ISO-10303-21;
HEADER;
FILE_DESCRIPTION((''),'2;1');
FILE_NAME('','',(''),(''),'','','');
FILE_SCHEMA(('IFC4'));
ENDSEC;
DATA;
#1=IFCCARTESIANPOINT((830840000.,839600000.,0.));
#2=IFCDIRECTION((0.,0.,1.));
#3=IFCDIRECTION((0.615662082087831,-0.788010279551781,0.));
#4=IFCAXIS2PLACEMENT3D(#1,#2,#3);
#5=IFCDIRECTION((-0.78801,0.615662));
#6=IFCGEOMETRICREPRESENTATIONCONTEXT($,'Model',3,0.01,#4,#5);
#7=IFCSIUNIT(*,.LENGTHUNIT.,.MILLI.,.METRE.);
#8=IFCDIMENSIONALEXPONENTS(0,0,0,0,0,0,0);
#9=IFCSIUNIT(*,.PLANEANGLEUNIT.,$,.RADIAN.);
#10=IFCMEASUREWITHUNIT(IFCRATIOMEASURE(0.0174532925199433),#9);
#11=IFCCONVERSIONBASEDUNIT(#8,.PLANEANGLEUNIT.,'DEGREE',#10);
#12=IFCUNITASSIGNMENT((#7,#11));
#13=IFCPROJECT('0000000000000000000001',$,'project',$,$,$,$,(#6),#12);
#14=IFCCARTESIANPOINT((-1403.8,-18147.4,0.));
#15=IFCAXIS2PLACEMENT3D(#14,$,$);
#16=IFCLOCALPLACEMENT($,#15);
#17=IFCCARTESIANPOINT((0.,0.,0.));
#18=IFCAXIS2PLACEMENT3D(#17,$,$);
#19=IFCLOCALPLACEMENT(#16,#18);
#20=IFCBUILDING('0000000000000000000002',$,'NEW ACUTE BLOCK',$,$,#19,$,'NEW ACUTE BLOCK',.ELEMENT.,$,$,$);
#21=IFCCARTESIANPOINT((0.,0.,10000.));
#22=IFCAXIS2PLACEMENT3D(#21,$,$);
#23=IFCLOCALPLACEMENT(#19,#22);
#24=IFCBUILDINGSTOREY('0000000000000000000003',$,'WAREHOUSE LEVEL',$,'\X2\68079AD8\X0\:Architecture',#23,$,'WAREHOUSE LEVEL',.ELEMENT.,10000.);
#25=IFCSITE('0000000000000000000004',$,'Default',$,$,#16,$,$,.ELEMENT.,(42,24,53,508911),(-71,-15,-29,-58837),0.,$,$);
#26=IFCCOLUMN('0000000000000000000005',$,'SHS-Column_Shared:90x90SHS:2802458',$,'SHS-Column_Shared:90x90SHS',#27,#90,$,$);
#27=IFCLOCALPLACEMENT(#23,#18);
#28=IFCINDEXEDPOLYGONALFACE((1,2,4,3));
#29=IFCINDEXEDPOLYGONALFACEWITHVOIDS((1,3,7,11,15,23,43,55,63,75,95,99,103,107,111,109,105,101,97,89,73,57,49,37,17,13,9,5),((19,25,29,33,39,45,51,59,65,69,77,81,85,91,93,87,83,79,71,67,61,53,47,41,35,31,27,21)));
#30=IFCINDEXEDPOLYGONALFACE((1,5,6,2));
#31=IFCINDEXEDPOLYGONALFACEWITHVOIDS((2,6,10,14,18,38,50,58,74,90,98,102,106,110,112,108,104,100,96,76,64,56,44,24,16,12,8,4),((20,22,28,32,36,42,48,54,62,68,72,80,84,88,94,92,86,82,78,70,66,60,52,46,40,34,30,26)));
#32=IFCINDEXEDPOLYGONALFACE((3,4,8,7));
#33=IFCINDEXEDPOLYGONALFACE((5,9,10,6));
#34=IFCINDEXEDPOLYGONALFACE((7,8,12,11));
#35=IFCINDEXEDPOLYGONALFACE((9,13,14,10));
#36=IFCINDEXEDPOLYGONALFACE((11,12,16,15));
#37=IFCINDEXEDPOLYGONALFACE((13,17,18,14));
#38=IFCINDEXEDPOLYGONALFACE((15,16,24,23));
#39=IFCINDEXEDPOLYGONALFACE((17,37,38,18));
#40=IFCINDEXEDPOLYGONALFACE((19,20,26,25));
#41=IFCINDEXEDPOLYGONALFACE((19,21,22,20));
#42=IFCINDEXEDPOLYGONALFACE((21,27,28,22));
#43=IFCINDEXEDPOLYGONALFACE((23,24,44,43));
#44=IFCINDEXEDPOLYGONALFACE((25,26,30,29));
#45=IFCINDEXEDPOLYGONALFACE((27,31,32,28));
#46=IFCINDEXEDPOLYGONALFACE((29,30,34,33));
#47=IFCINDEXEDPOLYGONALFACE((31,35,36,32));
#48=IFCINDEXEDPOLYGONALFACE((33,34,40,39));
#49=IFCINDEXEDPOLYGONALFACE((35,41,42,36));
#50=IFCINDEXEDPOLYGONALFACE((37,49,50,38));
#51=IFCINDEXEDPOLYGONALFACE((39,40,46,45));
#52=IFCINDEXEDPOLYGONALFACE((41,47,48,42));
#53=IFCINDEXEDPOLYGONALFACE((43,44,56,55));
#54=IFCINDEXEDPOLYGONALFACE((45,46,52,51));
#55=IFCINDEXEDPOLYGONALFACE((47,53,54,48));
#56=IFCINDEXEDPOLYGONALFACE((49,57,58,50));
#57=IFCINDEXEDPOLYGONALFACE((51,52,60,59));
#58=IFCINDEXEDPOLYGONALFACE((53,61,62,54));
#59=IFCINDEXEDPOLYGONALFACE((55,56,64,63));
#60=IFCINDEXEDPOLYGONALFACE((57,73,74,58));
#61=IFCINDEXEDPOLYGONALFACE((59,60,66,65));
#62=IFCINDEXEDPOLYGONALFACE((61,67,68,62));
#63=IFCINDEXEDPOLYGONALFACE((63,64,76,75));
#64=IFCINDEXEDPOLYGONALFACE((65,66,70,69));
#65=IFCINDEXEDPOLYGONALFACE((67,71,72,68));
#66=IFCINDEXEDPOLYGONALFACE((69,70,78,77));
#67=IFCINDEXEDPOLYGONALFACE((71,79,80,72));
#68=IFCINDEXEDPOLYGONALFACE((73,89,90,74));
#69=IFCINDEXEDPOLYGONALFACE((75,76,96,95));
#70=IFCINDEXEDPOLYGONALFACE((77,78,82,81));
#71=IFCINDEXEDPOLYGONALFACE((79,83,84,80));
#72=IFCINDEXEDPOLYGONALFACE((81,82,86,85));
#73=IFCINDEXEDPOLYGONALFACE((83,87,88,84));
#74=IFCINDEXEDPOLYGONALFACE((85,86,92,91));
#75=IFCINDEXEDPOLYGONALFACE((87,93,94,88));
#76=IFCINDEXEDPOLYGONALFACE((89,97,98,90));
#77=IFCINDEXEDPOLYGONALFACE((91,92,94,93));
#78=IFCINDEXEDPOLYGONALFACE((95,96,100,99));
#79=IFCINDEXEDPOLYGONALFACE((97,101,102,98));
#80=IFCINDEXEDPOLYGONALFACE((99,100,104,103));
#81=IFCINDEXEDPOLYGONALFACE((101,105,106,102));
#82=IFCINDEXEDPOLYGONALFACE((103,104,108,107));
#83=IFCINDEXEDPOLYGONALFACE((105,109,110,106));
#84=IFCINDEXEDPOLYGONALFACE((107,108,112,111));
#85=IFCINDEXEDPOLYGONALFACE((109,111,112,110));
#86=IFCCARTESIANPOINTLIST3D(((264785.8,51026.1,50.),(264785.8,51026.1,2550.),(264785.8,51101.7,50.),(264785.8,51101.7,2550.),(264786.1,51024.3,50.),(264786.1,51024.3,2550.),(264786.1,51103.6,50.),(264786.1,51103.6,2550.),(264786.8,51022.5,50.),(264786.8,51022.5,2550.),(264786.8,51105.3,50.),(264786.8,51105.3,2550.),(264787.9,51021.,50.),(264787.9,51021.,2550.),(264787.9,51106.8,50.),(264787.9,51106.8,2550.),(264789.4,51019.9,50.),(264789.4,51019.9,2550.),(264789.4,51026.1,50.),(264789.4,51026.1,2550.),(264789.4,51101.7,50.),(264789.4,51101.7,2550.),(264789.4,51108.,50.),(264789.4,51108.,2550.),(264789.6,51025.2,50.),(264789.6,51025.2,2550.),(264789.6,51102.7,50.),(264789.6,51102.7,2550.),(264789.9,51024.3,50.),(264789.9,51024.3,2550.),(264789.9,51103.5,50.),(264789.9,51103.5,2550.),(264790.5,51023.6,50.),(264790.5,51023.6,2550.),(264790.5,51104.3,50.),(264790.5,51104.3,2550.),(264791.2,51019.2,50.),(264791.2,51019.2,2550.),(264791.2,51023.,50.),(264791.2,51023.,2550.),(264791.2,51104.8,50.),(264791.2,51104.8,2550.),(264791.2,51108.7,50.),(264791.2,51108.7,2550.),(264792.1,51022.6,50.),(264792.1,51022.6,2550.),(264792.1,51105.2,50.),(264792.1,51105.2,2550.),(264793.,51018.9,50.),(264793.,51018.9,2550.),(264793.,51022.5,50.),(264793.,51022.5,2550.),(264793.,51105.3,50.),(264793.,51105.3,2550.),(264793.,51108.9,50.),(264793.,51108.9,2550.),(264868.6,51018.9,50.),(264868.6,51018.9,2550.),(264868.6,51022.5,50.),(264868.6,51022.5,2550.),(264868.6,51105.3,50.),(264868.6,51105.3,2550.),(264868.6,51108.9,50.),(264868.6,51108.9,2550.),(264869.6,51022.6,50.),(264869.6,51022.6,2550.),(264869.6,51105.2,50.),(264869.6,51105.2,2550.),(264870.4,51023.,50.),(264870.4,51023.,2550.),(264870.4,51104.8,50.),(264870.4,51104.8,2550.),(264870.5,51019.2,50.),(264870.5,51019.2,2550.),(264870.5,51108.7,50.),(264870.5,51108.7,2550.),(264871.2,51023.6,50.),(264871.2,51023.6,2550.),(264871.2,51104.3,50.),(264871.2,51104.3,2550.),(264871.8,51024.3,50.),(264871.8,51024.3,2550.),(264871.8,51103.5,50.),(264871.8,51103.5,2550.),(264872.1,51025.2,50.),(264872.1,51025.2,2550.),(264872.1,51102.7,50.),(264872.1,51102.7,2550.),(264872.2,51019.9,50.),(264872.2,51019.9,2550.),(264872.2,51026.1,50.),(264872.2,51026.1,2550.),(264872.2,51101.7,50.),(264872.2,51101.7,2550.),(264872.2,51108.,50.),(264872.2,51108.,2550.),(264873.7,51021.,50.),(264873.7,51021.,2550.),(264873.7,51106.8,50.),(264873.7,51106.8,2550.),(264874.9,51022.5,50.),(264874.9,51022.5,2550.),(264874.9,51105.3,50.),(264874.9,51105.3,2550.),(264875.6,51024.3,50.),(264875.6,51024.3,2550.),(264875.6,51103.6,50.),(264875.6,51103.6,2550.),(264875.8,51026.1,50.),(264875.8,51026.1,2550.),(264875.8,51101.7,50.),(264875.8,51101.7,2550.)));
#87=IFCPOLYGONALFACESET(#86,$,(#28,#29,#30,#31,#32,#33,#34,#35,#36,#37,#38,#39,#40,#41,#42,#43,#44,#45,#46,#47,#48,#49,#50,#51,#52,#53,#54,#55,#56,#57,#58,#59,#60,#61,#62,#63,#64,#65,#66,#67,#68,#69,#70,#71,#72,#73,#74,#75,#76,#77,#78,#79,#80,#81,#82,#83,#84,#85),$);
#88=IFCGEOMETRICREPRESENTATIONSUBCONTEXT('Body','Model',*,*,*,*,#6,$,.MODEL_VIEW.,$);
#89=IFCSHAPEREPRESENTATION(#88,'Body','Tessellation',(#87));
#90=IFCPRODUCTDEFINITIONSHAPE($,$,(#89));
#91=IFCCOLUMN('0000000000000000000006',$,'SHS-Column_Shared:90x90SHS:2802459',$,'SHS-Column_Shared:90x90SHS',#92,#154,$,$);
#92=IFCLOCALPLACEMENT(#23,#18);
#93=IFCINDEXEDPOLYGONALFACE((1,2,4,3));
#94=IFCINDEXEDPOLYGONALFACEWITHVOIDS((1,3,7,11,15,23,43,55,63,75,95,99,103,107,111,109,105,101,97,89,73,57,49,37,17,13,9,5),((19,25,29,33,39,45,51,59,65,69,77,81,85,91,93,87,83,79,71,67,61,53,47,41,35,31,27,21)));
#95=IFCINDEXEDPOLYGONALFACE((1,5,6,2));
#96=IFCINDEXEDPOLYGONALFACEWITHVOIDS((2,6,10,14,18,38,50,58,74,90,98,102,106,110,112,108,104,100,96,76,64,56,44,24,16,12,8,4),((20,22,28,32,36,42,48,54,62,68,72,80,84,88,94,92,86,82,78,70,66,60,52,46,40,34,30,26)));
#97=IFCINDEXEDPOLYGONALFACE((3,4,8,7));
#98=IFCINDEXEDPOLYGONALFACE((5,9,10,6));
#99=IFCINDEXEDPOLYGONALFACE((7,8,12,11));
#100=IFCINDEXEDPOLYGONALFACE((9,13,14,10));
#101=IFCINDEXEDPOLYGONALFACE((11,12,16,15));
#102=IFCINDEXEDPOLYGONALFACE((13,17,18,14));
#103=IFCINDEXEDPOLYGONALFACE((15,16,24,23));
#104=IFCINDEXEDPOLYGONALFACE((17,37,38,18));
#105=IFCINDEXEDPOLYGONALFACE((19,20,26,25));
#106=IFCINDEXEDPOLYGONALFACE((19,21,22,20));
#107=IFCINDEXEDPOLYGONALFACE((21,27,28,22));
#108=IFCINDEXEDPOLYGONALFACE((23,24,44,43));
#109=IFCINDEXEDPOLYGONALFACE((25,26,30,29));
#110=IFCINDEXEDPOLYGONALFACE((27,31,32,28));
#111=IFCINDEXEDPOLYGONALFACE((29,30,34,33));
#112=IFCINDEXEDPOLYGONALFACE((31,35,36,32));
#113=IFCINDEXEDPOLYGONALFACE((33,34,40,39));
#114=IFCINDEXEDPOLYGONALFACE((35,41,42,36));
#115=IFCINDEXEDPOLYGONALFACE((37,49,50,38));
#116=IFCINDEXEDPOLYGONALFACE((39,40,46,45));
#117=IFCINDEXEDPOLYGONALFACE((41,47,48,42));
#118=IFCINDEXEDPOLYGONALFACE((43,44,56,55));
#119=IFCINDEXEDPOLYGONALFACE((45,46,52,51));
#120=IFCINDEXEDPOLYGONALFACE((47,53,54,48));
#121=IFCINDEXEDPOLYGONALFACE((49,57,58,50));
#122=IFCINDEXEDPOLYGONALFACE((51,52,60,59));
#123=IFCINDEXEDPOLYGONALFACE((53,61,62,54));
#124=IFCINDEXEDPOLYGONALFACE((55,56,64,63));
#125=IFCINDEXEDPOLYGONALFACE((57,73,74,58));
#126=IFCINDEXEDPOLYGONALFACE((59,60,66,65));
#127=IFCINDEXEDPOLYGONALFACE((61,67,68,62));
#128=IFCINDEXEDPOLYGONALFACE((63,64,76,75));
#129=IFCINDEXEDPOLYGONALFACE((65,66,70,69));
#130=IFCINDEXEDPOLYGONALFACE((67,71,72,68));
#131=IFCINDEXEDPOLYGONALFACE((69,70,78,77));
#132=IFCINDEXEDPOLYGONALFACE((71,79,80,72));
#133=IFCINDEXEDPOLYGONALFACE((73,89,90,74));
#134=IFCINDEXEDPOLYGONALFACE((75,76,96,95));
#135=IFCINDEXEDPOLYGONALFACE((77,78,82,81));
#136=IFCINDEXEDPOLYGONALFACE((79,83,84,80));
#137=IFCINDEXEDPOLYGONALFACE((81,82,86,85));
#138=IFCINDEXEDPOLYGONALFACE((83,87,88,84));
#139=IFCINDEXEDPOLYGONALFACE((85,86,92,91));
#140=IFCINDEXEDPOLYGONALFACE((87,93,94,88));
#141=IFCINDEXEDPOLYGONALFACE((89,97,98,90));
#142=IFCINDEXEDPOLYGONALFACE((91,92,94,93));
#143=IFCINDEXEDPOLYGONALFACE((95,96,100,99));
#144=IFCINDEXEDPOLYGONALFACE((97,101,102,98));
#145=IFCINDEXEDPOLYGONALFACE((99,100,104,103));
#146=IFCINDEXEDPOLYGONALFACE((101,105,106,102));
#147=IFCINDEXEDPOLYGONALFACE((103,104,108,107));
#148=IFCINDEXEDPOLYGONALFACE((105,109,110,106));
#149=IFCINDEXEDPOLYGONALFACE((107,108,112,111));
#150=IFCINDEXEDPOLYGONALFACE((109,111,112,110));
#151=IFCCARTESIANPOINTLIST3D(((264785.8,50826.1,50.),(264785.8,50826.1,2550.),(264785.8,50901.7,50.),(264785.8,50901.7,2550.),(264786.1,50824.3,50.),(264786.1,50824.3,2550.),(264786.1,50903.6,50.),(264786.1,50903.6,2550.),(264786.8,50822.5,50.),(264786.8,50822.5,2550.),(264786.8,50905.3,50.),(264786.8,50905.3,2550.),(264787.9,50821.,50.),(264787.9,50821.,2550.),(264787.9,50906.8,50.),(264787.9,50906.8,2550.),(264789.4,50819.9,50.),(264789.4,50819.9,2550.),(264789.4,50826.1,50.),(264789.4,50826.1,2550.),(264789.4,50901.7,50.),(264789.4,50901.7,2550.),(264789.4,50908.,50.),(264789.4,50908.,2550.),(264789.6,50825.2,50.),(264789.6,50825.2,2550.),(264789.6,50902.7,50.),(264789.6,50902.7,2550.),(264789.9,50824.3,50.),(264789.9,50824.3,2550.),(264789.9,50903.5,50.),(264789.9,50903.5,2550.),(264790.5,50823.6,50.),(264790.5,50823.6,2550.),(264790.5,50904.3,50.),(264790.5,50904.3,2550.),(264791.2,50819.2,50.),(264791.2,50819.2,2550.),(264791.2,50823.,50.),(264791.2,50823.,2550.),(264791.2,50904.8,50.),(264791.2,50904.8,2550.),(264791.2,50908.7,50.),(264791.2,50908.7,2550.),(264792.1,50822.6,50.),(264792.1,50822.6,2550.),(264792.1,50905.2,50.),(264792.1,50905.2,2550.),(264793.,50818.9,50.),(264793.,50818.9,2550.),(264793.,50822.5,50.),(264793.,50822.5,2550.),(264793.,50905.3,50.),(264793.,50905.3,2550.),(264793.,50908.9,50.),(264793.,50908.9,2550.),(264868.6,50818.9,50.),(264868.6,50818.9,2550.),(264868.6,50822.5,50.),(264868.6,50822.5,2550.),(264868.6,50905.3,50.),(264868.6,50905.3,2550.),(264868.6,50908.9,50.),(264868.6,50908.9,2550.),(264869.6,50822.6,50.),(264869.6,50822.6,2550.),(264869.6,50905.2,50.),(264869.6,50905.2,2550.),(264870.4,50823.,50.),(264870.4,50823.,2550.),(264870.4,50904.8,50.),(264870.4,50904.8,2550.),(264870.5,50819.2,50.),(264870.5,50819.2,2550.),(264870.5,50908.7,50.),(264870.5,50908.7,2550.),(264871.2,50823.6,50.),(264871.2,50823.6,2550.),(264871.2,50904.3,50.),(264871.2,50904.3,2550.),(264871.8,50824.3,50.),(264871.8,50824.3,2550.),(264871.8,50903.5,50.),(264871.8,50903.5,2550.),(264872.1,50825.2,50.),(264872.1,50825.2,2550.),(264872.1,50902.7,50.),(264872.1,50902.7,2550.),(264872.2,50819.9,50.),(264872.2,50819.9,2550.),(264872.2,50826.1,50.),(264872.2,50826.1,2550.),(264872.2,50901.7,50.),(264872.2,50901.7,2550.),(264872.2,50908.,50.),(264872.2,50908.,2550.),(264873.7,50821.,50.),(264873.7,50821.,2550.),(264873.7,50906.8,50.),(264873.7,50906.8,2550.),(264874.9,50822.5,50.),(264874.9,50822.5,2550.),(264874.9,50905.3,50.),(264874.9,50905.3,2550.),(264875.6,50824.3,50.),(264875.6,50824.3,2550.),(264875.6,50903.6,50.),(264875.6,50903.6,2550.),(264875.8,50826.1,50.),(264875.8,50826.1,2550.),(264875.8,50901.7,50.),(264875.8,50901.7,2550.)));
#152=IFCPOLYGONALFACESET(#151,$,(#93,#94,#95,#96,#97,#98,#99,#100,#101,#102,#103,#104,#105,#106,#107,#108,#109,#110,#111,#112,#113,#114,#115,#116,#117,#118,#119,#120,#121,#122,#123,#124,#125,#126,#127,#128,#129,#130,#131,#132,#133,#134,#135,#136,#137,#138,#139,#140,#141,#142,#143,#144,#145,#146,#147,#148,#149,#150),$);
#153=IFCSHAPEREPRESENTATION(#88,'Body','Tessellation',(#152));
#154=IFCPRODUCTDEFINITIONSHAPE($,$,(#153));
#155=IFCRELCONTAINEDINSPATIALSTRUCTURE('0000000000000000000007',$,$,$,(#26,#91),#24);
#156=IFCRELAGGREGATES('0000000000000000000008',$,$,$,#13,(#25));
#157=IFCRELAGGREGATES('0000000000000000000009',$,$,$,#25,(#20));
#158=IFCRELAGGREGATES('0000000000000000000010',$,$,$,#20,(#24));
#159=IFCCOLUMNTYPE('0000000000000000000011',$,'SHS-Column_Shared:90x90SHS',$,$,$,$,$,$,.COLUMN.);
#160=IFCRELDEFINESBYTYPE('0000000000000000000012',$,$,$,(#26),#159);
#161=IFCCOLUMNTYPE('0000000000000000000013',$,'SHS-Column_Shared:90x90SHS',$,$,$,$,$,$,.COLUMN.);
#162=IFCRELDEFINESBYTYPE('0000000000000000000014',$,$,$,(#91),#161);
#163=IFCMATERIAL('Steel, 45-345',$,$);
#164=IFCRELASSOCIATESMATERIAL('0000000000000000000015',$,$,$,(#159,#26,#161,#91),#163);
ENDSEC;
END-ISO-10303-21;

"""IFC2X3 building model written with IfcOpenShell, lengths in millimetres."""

from ifc_helpers import new_model, entity, si_unit, converted_unit, direction, frame, frame_2d, origin, place, context, subcontext, project, spatial, polyline, circle_curve, parameter, trimmed, segment, composite_curve, outline, extrude, source, transform, mapped, material, type_object, type_shapes, element, save


model = new_model("IFC2X3")

# Units and contexts
model_context = context("Model", 3, precision=0.01, world=frame((830840000.0, 839600000.0, 0.0), z_axis=(0.0, 0.0, 1.0), x_axis=(0.615662082087831, -0.788010279551781, 0.0)), true_north=direction((-0.78801, 0.615662)))
body_context = subcontext(model_context, "Body", "Model", "MODEL_VIEW")
ifc_project = project(units=[si_unit("LENGTHUNIT", "METRE", prefix="MILLI"), converted_unit("PLANEANGLEUNIT", "DEGREE", entity("IfcRatioMeasure", 0.0174532925199433), si_unit("PLANEANGLEUNIT", "RADIAN"), dimensions=[0, 0, 0, 0, 0, 0, 0])], contexts=[model_context])

# Site, building, storey
site_placement = place(None, frame((-1403.8, -18147.4, 0.0)))
site = spatial("IfcSite", under=ifc_project, at=site_placement, Name="Default", CompositionType="ELEMENT", RefLatitude=(42, 24, 53, 508911), RefLongitude=(-71, -15, -29, -58837), RefElevation=0.0)
building_placement = place(site_placement, origin())
building = spatial("IfcBuilding", under=site, at=building_placement, Name="NEW ACUTE BLOCK", LongName="NEW ACUTE BLOCK", CompositionType="ELEMENT")
storey_placement = place(building_placement, frame((0.0, 0.0, 10000.0)))
storey = spatial("IfcBuildingStorey", under=building, at=storey_placement, Name="WAREHOUSE LEVEL", ObjectType="标高:Architecture", LongName="WAREHOUSE LEVEL", CompositionType="ELEMENT", Elevation=10000.0)

# Columns
ifc_material_1 = material(Name="Steel, 45-345")
column_type_1 = type_object("IfcColumnType", Name="SHS-Column_Shared:90x90SHS", PredefinedType="COLUMN", material=ifc_material_1)
shared_shape_1 = source(origin(), body_context, "Body", "SweptSolid", [
    extrude(outline(composite_curve([segment(polyline([(-37.8, -45.0), (37.8, -45.0)]), True, "CONTINUOUS"), segment(trimmed(circle_curve(frame_2d((37.8, -37.8), x_axis=(-1.0, 0.0)), 7.2), [parameter(90.0)], [parameter(180.0)], True, "PARAMETER"), True, "CONTINUOUS"), segment(polyline([(45.0, -37.8), (45.0, 37.8)]), True, "CONTINUOUS"), segment(trimmed(circle_curve(frame_2d((37.8, 37.8), x_axis=(-1.0, 0.0)), 7.2), [parameter(180.0)], [parameter(270.0)], True, "PARAMETER"), True, "CONTINUOUS"), segment(polyline([(37.8, 45.0), (-37.8, 45.0)]), True, "CONTINUOUS"), segment(trimmed(circle_curve(frame_2d((-37.8, 37.8), x_axis=(-1.0, 0.0)), 7.2), [parameter(270.0)], [parameter(360.0)], True, "PARAMETER"), True, "CONTINUOUS"), segment(polyline([(-45.0, 37.8), (-45.0, -37.8)]), True, "CONTINUOUS"), segment(trimmed(circle_curve(frame_2d((-37.8, -37.8), x_axis=(-1.0, 0.0)), 7.2), [parameter(360.0)], [parameter(90.0)], True, "PARAMETER"), True, "CONTINUOUS")], self_intersect=False), holes=[composite_curve([segment(trimmed(circle_curve(frame_2d((-37.8, -37.8), x_axis=(-1.0, 0.0)), 3.6), [parameter(0.0)], [parameter(90.0)], True, "PARAMETER"), False, "CONTINUOUS"), segment(polyline([(-41.4, -37.8), (-41.4, 37.8)]), True, "CONTINUOUS"), segment(trimmed(circle_curve(frame_2d((-37.8, 37.8), x_axis=(-1.0, 0.0)), 3.6), [parameter(270.0)], [parameter(360.0)], True, "PARAMETER"), False, "CONTINUOUS"), segment(polyline([(-37.8, 41.4), (37.8, 41.4)]), True, "CONTINUOUS"), segment(trimmed(circle_curve(frame_2d((37.8, 37.8), x_axis=(-1.0, 0.0)), 3.6), [parameter(180.0)], [parameter(270.0)], True, "PARAMETER"), False, "CONTINUOUS"), segment(polyline([(41.4, 37.8), (41.4, -37.8)]), True, "CONTINUOUS"), segment(trimmed(circle_curve(frame_2d((37.8, -37.8), x_axis=(-1.0, 0.0)), 3.6), [parameter(90.0)], [parameter(180.0)], True, "PARAMETER"), False, "CONTINUOUS"), segment(polyline([(37.8, -41.4), (-37.8, -41.4)]), True, "CONTINUOUS")], self_intersect=False)]), frame((0.0, 0.0, 0.0), z_axis=(0.0, 0.0, 1.0), x_axis=(-1.0, 0.0, 0.0)), (0.0, 0.0, 1.0), 2500.0),
])
type_shapes(column_type_1, [shared_shape_1])
column_1_placement = place(storey_placement, frame((264830.8, 51063.9, 50.0), z_axis=(0.0, 0.0, 1.0), x_axis=(0.0, -1.0, 0.0)))
element("IfcColumn", 1, at=column_1_placement, inside=storey, type_object=column_type_1, material=ifc_material_1, Name="SHS-Column_Shared:90x90SHS:2802458", ObjectType="SHS-Column_Shared:90x90SHS", context=body_context, shape_type="MappedRepresentation", body=[
    mapped(shared_shape_1, transform((0.0, 0.0, 0.0), scale=1.0)),
])
column_type_2 = type_object("IfcColumnType", Name="SHS-Column_Shared:90x90SHS", PredefinedType="COLUMN", material=ifc_material_1)
shared_shape_2 = source(origin(), body_context, "Body", "SweptSolid", [
    extrude(outline(composite_curve([segment(trimmed(circle_curve(frame_2d((37.8, -37.8), x_axis=(1.0, 0.0)), 7.2), [parameter(270.0)], [parameter(0.0)], True, "PARAMETER"), True, "CONTINUOUS"), segment(polyline([(45.0, -37.8), (45.0, 37.8)]), True, "CONTINUOUS"), segment(trimmed(circle_curve(frame_2d((37.8, 37.8), x_axis=(1.0, 0.0)), 7.2), [parameter(0.0)], [parameter(90.0)], True, "PARAMETER"), True, "CONTINUOUS"), segment(polyline([(37.8, 45.0), (-37.8, 45.0)]), True, "CONTINUOUS"), segment(trimmed(circle_curve(frame_2d((-37.8, 37.8), x_axis=(1.0, 0.0)), 7.2), [parameter(90.0)], [parameter(180.0)], True, "PARAMETER"), True, "CONTINUOUS"), segment(polyline([(-45.0, 37.8), (-45.0, -37.8)]), True, "CONTINUOUS"), segment(trimmed(circle_curve(frame_2d((-37.8, -37.8), x_axis=(1.0, 0.0)), 7.2), [parameter(180.0)], [parameter(270.0)], True, "PARAMETER"), True, "CONTINUOUS"), segment(polyline([(-37.8, -45.0), (37.8, -45.0)]), True, "CONTINUOUS")], self_intersect=False), holes=[composite_curve([segment(polyline([(37.8, -41.4), (-37.8, -41.4)]), True, "CONTINUOUS"), segment(trimmed(circle_curve(frame_2d((-37.8, -37.8), x_axis=(1.0, 0.0)), 3.6), [parameter(180.0)], [parameter(270.0)], True, "PARAMETER"), False, "CONTINUOUS"), segment(polyline([(-41.4, -37.8), (-41.4, 37.8)]), True, "CONTINUOUS"), segment(trimmed(circle_curve(frame_2d((-37.8, 37.8), x_axis=(1.0, 0.0)), 3.6), [parameter(90.0)], [parameter(180.0)], True, "PARAMETER"), False, "CONTINUOUS"), segment(polyline([(-37.8, 41.4), (37.8, 41.4)]), True, "CONTINUOUS"), segment(trimmed(circle_curve(frame_2d((37.8, 37.8), x_axis=(1.0, 0.0)), 3.6), [parameter(0.0)], [parameter(90.0)], True, "PARAMETER"), False, "CONTINUOUS"), segment(polyline([(41.4, 37.8), (41.4, -37.8)]), True, "CONTINUOUS"), segment(trimmed(circle_curve(frame_2d((37.8, -37.8), x_axis=(1.0, 0.0)), 3.6), [parameter(270.0)], [parameter(0.0)], True, "PARAMETER"), False, "CONTINUOUS")], self_intersect=False)]), origin(), (0.0, 0.0, 1.0), 2500.0),
])
type_shapes(column_type_2, [shared_shape_2])
column_2_placement = place(storey_placement, frame((264830.8, 50863.9, 50.0), z_axis=(0.0, 0.0, 1.0), x_axis=(0.0, 1.0, 0.0)))
element("IfcColumn", 2, at=column_2_placement, inside=storey, type_object=column_type_2, material=ifc_material_1, Name="SHS-Column_Shared:90x90SHS:2802459", ObjectType="SHS-Column_Shared:90x90SHS", context=body_context, shape_type="MappedRepresentation", body=[
    mapped(shared_shape_2, transform((0.0, 0.0, 0.0), scale=1.0)),
])

save(model, "model.ifc")
